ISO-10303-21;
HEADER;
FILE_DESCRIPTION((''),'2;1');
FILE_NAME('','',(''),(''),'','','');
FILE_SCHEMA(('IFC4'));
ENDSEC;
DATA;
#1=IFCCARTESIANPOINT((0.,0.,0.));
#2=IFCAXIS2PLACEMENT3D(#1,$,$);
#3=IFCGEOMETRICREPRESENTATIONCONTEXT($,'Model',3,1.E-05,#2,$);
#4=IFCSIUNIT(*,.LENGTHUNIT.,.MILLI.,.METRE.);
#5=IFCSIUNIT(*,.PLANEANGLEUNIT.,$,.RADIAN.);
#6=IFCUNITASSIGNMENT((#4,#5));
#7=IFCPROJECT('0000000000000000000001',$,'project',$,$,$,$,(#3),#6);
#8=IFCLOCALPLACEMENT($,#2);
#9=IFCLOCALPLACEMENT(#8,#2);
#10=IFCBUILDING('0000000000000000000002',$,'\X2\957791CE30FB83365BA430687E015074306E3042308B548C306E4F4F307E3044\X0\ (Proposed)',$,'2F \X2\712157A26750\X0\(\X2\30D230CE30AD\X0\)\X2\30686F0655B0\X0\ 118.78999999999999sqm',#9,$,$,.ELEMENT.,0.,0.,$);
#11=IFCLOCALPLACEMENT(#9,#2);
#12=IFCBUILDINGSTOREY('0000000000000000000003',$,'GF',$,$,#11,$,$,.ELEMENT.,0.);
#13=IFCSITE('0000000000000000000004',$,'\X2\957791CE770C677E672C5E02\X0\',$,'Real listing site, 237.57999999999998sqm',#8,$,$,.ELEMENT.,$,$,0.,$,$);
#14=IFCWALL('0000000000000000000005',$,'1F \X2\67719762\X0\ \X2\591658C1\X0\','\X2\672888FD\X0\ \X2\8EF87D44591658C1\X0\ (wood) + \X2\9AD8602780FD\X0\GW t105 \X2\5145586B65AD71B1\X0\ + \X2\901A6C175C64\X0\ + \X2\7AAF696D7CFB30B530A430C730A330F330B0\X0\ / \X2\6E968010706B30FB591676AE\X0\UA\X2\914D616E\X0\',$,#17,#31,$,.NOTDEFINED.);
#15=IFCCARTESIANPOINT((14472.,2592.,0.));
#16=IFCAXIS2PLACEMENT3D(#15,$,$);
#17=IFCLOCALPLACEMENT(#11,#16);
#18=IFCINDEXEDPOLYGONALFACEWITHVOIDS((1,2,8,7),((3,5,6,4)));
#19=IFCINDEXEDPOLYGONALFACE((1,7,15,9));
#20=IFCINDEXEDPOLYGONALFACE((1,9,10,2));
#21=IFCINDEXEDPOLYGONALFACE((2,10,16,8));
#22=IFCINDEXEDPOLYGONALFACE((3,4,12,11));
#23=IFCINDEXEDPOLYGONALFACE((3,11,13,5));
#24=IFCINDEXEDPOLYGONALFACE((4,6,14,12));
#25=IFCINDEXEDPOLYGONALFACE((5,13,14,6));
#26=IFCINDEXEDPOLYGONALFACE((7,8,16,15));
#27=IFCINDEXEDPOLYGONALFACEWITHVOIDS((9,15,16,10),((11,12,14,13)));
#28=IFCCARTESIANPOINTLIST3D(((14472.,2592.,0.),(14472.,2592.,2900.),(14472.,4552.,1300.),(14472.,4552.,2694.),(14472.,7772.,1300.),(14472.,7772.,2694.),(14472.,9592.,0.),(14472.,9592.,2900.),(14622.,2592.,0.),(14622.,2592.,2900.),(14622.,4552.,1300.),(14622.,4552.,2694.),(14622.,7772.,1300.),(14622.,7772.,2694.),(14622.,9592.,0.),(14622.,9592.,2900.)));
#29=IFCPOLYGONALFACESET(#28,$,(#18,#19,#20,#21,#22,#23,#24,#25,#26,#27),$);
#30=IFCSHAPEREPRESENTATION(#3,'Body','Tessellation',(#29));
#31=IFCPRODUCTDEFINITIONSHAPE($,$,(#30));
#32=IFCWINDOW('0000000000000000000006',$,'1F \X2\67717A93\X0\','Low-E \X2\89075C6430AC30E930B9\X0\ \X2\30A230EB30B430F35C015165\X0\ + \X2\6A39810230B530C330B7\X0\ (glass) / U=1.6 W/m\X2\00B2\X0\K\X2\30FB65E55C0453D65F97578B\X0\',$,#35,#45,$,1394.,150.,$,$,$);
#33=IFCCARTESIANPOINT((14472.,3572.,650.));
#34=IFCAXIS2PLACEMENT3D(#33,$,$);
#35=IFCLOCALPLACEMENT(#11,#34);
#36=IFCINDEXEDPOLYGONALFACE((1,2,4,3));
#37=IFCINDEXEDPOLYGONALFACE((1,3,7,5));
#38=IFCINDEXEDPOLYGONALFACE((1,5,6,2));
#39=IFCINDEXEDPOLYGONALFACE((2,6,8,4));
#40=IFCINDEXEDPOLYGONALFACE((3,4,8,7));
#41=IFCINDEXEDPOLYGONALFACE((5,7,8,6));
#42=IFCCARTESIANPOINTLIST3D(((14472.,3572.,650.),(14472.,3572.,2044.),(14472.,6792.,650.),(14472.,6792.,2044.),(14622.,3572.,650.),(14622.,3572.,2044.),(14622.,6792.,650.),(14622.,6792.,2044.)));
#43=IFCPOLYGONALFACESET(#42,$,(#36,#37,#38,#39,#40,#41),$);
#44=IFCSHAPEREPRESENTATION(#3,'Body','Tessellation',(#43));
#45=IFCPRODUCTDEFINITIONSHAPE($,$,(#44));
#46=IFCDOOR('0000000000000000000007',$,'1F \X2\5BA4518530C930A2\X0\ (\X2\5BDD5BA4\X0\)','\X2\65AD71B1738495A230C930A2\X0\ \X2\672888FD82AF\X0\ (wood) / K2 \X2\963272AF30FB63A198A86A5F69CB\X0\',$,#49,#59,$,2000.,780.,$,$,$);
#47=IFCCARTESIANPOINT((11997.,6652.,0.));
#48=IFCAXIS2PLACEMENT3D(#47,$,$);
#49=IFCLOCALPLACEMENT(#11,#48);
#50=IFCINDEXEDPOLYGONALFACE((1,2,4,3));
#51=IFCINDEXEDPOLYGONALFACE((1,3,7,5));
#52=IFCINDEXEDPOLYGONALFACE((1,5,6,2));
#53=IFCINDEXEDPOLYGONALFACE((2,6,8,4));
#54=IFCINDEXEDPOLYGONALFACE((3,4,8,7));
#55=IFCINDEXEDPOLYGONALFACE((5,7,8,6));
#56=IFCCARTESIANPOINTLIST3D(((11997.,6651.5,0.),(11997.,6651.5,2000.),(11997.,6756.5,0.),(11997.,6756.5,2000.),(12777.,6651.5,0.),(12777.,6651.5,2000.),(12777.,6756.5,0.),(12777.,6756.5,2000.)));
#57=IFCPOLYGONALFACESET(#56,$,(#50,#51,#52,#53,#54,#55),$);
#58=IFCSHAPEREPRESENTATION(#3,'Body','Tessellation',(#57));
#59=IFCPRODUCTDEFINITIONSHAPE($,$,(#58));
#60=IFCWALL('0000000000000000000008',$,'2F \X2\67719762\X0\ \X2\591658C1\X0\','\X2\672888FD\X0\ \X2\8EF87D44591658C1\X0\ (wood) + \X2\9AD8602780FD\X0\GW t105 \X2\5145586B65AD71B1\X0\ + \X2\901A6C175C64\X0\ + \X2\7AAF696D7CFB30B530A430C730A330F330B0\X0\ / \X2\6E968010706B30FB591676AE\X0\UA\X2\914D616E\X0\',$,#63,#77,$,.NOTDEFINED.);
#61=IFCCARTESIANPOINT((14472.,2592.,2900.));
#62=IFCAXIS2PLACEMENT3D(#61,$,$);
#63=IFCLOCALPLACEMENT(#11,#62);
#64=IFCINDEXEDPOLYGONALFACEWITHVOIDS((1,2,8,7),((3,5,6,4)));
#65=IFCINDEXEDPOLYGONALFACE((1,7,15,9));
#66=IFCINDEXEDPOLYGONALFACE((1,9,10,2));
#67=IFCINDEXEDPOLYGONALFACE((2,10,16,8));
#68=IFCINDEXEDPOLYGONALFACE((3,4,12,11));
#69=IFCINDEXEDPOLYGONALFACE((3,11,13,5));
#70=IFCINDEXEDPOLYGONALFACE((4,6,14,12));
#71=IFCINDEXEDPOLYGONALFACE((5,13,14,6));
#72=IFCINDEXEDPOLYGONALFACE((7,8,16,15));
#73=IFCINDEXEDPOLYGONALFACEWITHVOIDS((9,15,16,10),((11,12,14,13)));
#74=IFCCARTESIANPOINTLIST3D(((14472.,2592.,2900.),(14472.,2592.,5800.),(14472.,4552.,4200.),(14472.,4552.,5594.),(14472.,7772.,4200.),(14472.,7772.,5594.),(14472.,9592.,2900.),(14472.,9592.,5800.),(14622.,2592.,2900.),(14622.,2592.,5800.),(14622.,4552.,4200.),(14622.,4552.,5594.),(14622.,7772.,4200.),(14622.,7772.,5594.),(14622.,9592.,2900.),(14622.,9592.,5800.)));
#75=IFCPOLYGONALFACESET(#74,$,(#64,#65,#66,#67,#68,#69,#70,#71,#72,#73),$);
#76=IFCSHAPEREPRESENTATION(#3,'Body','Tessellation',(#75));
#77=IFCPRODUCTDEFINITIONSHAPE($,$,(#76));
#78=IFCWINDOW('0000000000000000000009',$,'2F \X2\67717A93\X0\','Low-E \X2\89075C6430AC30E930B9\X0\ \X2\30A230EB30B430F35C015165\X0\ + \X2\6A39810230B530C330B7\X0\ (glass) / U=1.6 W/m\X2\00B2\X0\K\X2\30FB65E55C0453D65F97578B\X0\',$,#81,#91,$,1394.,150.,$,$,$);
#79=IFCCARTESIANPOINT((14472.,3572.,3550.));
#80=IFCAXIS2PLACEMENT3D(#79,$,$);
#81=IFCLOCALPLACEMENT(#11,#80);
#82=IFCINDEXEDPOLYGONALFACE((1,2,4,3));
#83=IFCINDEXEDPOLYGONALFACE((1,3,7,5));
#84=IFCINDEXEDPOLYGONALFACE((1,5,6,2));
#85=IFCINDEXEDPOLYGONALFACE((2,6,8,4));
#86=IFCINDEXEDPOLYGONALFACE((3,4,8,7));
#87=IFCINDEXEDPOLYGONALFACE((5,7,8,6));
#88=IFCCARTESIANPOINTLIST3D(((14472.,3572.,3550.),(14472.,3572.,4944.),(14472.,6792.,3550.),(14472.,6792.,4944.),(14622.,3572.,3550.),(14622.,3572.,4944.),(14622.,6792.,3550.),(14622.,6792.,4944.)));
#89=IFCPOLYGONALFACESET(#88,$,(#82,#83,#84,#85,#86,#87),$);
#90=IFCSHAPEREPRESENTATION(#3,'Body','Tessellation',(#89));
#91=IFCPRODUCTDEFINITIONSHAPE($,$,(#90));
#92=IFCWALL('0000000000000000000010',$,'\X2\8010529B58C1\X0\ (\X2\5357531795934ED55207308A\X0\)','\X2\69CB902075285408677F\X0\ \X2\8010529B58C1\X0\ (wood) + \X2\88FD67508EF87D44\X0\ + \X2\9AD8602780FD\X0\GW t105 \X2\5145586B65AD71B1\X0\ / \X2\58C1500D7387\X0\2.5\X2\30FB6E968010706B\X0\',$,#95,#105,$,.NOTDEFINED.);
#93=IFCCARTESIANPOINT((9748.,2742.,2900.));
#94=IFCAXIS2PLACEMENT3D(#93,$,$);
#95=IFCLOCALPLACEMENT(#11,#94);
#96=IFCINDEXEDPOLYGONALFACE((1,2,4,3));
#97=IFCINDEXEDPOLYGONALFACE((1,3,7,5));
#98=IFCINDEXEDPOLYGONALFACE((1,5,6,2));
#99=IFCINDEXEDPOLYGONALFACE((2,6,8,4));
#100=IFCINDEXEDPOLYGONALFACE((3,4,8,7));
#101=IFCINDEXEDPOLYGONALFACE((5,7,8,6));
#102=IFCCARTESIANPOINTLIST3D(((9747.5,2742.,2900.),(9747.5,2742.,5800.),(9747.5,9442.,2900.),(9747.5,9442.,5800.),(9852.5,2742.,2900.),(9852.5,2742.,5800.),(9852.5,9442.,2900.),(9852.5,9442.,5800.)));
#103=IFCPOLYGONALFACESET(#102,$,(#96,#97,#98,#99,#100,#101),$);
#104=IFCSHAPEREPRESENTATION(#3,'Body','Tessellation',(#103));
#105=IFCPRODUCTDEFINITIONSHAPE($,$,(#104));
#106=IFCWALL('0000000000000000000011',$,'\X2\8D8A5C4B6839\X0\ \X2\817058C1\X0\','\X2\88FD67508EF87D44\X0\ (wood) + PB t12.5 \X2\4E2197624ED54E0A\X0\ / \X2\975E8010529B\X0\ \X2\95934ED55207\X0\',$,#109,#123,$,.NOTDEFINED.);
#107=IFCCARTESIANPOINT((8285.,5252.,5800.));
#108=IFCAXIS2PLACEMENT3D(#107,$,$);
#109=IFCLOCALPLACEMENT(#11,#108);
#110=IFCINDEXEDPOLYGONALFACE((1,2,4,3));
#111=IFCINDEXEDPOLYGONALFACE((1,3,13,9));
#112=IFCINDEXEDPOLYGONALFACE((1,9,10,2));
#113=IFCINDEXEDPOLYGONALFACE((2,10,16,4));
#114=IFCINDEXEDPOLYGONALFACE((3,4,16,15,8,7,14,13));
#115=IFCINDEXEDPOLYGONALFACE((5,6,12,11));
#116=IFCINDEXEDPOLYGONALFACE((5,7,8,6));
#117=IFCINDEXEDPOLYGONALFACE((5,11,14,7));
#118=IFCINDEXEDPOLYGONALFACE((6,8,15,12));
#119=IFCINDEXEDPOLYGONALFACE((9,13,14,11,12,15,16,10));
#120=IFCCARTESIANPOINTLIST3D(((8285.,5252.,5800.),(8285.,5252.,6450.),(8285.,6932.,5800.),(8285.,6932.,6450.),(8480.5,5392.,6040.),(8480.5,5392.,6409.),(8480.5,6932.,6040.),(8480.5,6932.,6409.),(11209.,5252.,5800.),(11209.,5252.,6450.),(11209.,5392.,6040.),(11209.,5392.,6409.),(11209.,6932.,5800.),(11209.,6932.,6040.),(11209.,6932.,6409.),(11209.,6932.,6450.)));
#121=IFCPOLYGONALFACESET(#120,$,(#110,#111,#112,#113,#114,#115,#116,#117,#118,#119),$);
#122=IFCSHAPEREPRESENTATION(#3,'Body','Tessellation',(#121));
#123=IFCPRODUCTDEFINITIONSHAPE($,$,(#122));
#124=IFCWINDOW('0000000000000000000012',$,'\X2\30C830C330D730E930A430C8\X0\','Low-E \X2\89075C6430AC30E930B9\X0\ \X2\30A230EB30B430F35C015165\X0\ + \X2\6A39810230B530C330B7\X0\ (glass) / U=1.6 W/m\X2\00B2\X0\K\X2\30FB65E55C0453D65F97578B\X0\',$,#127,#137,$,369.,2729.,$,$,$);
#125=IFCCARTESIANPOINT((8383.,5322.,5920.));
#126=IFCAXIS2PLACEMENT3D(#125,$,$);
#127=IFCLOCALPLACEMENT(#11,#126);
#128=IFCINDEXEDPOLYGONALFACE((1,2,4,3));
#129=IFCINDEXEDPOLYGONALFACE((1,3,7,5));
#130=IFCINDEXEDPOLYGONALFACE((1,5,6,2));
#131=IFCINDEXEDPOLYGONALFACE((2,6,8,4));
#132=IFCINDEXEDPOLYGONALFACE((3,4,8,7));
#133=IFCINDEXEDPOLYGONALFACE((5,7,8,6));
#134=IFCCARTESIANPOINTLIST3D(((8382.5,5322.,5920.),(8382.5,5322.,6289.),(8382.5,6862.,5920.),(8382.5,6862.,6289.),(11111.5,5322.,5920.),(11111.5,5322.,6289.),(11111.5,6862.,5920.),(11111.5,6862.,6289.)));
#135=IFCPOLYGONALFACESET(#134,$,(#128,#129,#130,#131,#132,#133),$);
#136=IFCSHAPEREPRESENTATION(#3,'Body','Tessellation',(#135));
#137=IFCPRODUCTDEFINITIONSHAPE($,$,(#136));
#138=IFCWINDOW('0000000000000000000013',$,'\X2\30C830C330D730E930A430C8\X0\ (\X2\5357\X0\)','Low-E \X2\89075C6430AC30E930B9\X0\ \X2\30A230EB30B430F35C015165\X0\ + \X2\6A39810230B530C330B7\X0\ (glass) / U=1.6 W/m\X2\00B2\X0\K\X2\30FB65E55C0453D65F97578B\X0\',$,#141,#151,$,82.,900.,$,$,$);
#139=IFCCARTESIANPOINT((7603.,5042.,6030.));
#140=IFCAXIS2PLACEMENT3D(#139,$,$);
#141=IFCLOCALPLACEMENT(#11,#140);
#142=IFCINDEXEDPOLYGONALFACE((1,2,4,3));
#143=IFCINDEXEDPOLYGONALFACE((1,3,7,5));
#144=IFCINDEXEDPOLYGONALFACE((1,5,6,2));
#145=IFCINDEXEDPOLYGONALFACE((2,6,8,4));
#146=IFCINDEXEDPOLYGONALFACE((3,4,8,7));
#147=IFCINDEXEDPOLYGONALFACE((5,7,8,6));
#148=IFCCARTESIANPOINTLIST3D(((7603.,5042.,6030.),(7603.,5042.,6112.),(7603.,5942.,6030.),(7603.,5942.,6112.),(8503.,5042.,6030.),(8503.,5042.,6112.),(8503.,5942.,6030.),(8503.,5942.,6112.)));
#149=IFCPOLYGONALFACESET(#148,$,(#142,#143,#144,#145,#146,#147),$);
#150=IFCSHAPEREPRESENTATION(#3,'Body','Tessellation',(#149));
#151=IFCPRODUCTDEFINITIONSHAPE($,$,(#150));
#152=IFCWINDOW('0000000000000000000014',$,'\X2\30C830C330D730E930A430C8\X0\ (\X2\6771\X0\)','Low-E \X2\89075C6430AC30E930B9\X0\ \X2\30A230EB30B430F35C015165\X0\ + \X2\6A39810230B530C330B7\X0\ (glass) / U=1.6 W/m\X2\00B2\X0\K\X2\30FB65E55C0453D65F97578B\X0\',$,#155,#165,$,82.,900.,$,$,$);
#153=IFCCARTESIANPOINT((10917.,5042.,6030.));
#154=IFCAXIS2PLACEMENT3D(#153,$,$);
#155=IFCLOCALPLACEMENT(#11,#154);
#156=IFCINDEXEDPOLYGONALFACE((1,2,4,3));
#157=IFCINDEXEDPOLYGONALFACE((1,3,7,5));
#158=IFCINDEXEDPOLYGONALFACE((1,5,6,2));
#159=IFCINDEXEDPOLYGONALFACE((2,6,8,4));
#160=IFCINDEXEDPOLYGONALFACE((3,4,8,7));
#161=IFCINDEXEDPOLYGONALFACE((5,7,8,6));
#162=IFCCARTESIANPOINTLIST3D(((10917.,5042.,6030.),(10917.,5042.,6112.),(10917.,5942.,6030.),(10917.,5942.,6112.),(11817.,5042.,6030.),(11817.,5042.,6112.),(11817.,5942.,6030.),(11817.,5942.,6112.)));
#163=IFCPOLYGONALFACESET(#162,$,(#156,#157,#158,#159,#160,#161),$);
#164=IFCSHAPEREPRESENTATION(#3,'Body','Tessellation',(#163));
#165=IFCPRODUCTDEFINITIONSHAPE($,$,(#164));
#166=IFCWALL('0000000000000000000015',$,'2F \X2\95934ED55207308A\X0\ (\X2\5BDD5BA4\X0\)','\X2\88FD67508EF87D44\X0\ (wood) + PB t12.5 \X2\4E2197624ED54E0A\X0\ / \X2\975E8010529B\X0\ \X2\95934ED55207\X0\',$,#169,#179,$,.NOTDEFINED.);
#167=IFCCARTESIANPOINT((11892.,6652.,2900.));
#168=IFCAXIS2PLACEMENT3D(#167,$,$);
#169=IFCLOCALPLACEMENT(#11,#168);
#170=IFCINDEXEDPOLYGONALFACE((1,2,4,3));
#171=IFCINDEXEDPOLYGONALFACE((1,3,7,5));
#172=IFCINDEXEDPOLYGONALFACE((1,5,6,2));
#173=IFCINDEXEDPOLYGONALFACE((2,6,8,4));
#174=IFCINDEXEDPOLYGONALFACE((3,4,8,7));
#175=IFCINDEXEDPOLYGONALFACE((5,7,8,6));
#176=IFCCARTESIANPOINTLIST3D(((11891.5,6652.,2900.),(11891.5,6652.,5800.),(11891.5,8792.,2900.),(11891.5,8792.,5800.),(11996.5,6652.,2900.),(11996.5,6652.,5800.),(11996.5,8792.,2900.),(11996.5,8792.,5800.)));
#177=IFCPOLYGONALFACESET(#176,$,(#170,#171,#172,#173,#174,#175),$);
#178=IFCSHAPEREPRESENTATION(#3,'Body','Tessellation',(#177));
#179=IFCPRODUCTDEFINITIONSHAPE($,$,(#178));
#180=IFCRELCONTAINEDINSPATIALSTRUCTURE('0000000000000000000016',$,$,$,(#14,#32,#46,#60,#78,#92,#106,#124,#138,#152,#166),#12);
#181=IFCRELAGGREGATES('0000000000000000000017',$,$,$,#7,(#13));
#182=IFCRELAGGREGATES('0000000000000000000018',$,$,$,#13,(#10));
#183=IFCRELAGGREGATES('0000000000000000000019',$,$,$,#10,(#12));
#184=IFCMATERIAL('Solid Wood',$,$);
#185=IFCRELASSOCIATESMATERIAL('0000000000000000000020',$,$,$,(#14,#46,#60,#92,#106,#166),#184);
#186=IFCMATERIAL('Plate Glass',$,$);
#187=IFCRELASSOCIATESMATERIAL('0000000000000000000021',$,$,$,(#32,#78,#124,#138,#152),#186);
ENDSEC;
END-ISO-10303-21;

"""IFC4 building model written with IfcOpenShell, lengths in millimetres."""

from ifc_helpers import new_model, si_unit, frame, frame_2d, origin, place, context, project, spatial, rectangle, extrude, material, element, fill, save


model = new_model("IFC4")

# Units and contexts
model_context = context("Model", 3, precision=1e-05, world=origin())
ifc_project = project(units=[si_unit("LENGTHUNIT", "METRE", prefix="MILLI"), si_unit("PLANEANGLEUNIT", "RADIAN")], contexts=[model_context])

# Site, building, storey
site_placement = place(None, origin())
site = spatial("IfcSite", under=ifc_project, at=site_placement, Name="長野県松本市", ObjectType="Real listing site, 237.57999999999998sqm", CompositionType="ELEMENT", RefElevation=0.0)
building_placement = place(site_placement, origin())
building = spatial("IfcBuilding", under=site, at=building_placement, Name="長野・茶室と縁側のある和の住まい (Proposed)", ObjectType="2F 無垢材(ヒノキ)と漆喰 118.78999999999999sqm", CompositionType="ELEMENT", ElevationOfRefHeight=0.0, ElevationOfTerrain=0.0)
storey_placement = place(building_placement, origin())
storey = spatial("IfcBuildingStorey", under=building, at=storey_placement, Name="GF", CompositionType="ELEMENT", Elevation=0.0)

# Wall, opening, window
ifc_material_1 = material(Name="Solid Wood")
wall_1_placement = place(storey_placement, frame((14472.0, 2592.0, 0.0)))
wall_1 = element("IfcWall", 1, at=wall_1_placement, inside=storey, material=ifc_material_1, Name="1F 東面 外壁", Description="木製 軸組外壁 (wood) + 高性能GW t105 充填断熱 + 通気層 + 窯業系サイディング / 準耐火・外皮UA配慮", PredefinedType="NOTDEFINED", context=model_context, shape_type="SweptSolid", body=[
    extrude(rectangle(XDim=150.0, YDim=7000.0, at=frame_2d((75.0, 3500.0))), frame((14472.0, 2592.0, 0.0)), (0.0, 0.0, 1.0), 2900.0),
])
opening_1_placement = place(storey_placement, frame((14472.0, 3572.0, 650.0)))
opening_1 = element("IfcOpeningElement", 2, at=opening_1_placement, cuts=wall_1, PredefinedType="NOTDEFINED", context=model_context, shape_type="SweptSolid", body=[
    extrude(rectangle(XDim=150.0, YDim=3220.0, at=frame_2d((75.0, 1610.0))), frame((14472.0, 3572.0, 650.0)), (0.0, 0.0, 1.0), 1394.0),
])
ifc_material_2 = material(Name="Plate Glass")
window_1_placement = place(storey_placement, frame((14472.0, 3572.0, 650.0)))
window_1 = element("IfcWindow", 3, at=window_1_placement, inside=storey, material=ifc_material_2, Name="1F 東窓", Description="Low-E 複層ガラス アルゴン封入 + 樹脂サッシ (glass) / U=1.6 W/m²K・日射取得型", OverallHeight=1394.0, OverallWidth=150.0, context=model_context, shape_type="SweptSolid", body=[
    extrude(rectangle(XDim=150.0, YDim=3220.0, at=frame_2d((75.0, 1610.0))), frame((14472.0, 3572.0, 650.0)), (0.0, 0.0, 1.0), 1394.0),
])
fill(opening_1, window_1)

# Door
door_1_placement = place(storey_placement, frame((11997.0, 6652.0, 0.0)))
element("IfcDoor", 4, at=door_1_placement, inside=storey, material=ifc_material_1, Name="1F 室内ドア (寝室)", Description="断熱玄関ドア 木製芯 (wood) / K2 防犯・採風機構", OverallHeight=2000.0, OverallWidth=780.0, context=model_context, shape_type="SweptSolid", body=[
    extrude(rectangle(XDim=780.0, YDim=105.0, at=frame_2d((390.0, 52.0))), frame((11997.0, 6652.0, 0.0)), (0.0, 0.0, 1.0), 2000.0),
])

# Wall, opening, window
wall_2_placement = place(storey_placement, frame((14472.0, 2592.0, 2900.0)))
wall_2 = element("IfcWall", 5, at=wall_2_placement, inside=storey, material=ifc_material_1, Name="2F 東面 外壁", Description="木製 軸組外壁 (wood) + 高性能GW t105 充填断熱 + 通気層 + 窯業系サイディング / 準耐火・外皮UA配慮", PredefinedType="NOTDEFINED", context=model_context, shape_type="SweptSolid", body=[
    extrude(rectangle(XDim=150.0, YDim=7000.0, at=frame_2d((75.0, 3500.0))), frame((14472.0, 2592.0, 2900.0)), (0.0, 0.0, 1.0), 2900.0),
])
opening_2_placement = place(storey_placement, frame((14472.0, 3572.0, 3550.0)))
opening_2 = element("IfcOpeningElement", 6, at=opening_2_placement, cuts=wall_2, PredefinedType="NOTDEFINED", context=model_context, shape_type="SweptSolid", body=[
    extrude(rectangle(XDim=150.0, YDim=3220.0, at=frame_2d((75.0, 1610.0))), frame((14472.0, 3572.0, 3550.0)), (0.0, 0.0, 1.0), 1394.0),
])
window_2_placement = place(storey_placement, frame((14472.0, 3572.0, 3550.0)))
window_2 = element("IfcWindow", 7, at=window_2_placement, inside=storey, material=ifc_material_2, Name="2F 東窓", Description="Low-E 複層ガラス アルゴン封入 + 樹脂サッシ (glass) / U=1.6 W/m²K・日射取得型", OverallHeight=1394.0, OverallWidth=150.0, context=model_context, shape_type="SweptSolid", body=[
    extrude(rectangle(XDim=150.0, YDim=3220.0, at=frame_2d((75.0, 1610.0))), frame((14472.0, 3572.0, 3550.0)), (0.0, 0.0, 1.0), 1394.0),
])
fill(opening_2, window_2)

# Wall
wall_3_placement = place(storey_placement, frame((9748.0, 2742.0, 2900.0)))
element("IfcWall", 8, at=wall_3_placement, inside=storey, material=ifc_material_1, Name="耐力壁 (南北間仕切り)", Description="構造用合板 耐力壁 (wood) + 製材軸組 + 高性能GW t105 充填断熱 / 壁倍率2.5・準耐火", PredefinedType="NOTDEFINED", context=model_context, shape_type="SweptSolid", body=[
    extrude(rectangle(XDim=105.0, YDim=6700.0, at=frame_2d((52.0, 3350.0))), frame((9748.0, 2742.0, 2900.0)), (0.0, 0.0, 1.0), 2900.0),
])

# Wall, openings, windows
wall_4_placement = place(storey_placement, frame((8285.0, 5252.0, 5800.0)))
wall_4 = element("IfcWall", 9, at=wall_4_placement, inside=storey, material=ifc_material_1, Name="越屋根 腰壁", Description="製材軸組 (wood) + PB t12.5 両面仕上 / 非耐力 間仕切", PredefinedType="NOTDEFINED", context=model_context, shape_type="SweptSolid", body=[
    extrude(rectangle(XDim=2924.0, YDim=1680.0, at=frame_2d((1462.0, 840.0))), frame((8285.0, 5252.0, 5800.0)), (0.0, 0.0, 1.0), 650.0),
])
opening_3_placement = place(storey_placement, frame((8383.0, 5322.0, 5920.0)))
opening_3 = element("IfcOpeningElement", 10, at=opening_3_placement, cuts=wall_4, PredefinedType="NOTDEFINED", context=model_context, shape_type="SweptSolid", body=[
    extrude(rectangle(XDim=2729.0, YDim=1540.0, at=frame_2d((1364.0, 770.0))), frame((8383.0, 5322.0, 5920.0)), (0.0, 0.0, 1.0), 369.0),
])
opening_4_placement = place(storey_placement, frame((7603.0, 5042.0, 6030.0)))
opening_4 = element("IfcOpeningElement", 11, at=opening_4_placement, cuts=wall_4, PredefinedType="NOTDEFINED", context=model_context, shape_type="SweptSolid", body=[
    extrude(rectangle(XDim=900.0, YDim=900.0, at=frame_2d((450.0, 450.0))), frame((7603.0, 5042.0, 6030.0)), (0.0, 0.0, 1.0), 82.0),
])
opening_5_placement = place(storey_placement, frame((10917.0, 5042.0, 6030.0)))
opening_5 = element("IfcOpeningElement", 12, at=opening_5_placement, cuts=wall_4, PredefinedType="NOTDEFINED", context=model_context, shape_type="SweptSolid", body=[
    extrude(rectangle(XDim=900.0, YDim=900.0, at=frame_2d((450.0, 450.0))), frame((10917.0, 5042.0, 6030.0)), (0.0, 0.0, 1.0), 82.0),
])
window_3_placement = place(storey_placement, frame((8383.0, 5322.0, 5920.0)))
window_3 = element("IfcWindow", 13, at=window_3_placement, inside=storey, material=ifc_material_2, Name="トップライト", Description="Low-E 複層ガラス アルゴン封入 + 樹脂サッシ (glass) / U=1.6 W/m²K・日射取得型", OverallHeight=369.0, OverallWidth=2729.0, context=model_context, shape_type="SweptSolid", body=[
    extrude(rectangle(XDim=2729.0, YDim=1540.0, at=frame_2d((1364.0, 770.0))), frame((8383.0, 5322.0, 5920.0)), (0.0, 0.0, 1.0), 369.0),
])
fill(opening_3, window_3)
window_4_placement = place(storey_placement, frame((7603.0, 5042.0, 6030.0)))
window_4 = element("IfcWindow", 14, at=window_4_placement, inside=storey, material=ifc_material_2, Name="トップライト (南)", Description="Low-E 複層ガラス アルゴン封入 + 樹脂サッシ (glass) / U=1.6 W/m²K・日射取得型", OverallHeight=82.0, OverallWidth=900.0, context=model_context, shape_type="SweptSolid", body=[
    extrude(rectangle(XDim=900.0, YDim=900.0, at=frame_2d((450.0, 450.0))), frame((7603.0, 5042.0, 6030.0)), (0.0, 0.0, 1.0), 82.0),
])
fill(opening_4, window_4)
window_5_placement = place(storey_placement, frame((10917.0, 5042.0, 6030.0)))
window_5 = element("IfcWindow", 15, at=window_5_placement, inside=storey, material=ifc_material_2, Name="トップライト (東)", Description="Low-E 複層ガラス アルゴン封入 + 樹脂サッシ (glass) / U=1.6 W/m²K・日射取得型", OverallHeight=82.0, OverallWidth=900.0, context=model_context, shape_type="SweptSolid", body=[
    extrude(rectangle(XDim=900.0, YDim=900.0, at=frame_2d((450.0, 450.0))), frame((10917.0, 5042.0, 6030.0)), (0.0, 0.0, 1.0), 82.0),
])
fill(opening_5, window_5)

# Wall
wall_5_placement = place(storey_placement, frame((11892.0, 6652.0, 2900.0)))
element("IfcWall", 16, at=wall_5_placement, inside=storey, material=ifc_material_1, Name="2F 間仕切り (寝室)", Description="製材軸組 (wood) + PB t12.5 両面仕上 / 非耐力 間仕切", PredefinedType="NOTDEFINED", context=model_context, shape_type="SweptSolid", body=[
    extrude(rectangle(XDim=105.0, YDim=2140.0, at=frame_2d((52.0, 1070.0))), frame((11892.0, 6652.0, 2900.0)), (0.0, 0.0, 1.0), 2900.0),
])

save(model, "model.ifc")
